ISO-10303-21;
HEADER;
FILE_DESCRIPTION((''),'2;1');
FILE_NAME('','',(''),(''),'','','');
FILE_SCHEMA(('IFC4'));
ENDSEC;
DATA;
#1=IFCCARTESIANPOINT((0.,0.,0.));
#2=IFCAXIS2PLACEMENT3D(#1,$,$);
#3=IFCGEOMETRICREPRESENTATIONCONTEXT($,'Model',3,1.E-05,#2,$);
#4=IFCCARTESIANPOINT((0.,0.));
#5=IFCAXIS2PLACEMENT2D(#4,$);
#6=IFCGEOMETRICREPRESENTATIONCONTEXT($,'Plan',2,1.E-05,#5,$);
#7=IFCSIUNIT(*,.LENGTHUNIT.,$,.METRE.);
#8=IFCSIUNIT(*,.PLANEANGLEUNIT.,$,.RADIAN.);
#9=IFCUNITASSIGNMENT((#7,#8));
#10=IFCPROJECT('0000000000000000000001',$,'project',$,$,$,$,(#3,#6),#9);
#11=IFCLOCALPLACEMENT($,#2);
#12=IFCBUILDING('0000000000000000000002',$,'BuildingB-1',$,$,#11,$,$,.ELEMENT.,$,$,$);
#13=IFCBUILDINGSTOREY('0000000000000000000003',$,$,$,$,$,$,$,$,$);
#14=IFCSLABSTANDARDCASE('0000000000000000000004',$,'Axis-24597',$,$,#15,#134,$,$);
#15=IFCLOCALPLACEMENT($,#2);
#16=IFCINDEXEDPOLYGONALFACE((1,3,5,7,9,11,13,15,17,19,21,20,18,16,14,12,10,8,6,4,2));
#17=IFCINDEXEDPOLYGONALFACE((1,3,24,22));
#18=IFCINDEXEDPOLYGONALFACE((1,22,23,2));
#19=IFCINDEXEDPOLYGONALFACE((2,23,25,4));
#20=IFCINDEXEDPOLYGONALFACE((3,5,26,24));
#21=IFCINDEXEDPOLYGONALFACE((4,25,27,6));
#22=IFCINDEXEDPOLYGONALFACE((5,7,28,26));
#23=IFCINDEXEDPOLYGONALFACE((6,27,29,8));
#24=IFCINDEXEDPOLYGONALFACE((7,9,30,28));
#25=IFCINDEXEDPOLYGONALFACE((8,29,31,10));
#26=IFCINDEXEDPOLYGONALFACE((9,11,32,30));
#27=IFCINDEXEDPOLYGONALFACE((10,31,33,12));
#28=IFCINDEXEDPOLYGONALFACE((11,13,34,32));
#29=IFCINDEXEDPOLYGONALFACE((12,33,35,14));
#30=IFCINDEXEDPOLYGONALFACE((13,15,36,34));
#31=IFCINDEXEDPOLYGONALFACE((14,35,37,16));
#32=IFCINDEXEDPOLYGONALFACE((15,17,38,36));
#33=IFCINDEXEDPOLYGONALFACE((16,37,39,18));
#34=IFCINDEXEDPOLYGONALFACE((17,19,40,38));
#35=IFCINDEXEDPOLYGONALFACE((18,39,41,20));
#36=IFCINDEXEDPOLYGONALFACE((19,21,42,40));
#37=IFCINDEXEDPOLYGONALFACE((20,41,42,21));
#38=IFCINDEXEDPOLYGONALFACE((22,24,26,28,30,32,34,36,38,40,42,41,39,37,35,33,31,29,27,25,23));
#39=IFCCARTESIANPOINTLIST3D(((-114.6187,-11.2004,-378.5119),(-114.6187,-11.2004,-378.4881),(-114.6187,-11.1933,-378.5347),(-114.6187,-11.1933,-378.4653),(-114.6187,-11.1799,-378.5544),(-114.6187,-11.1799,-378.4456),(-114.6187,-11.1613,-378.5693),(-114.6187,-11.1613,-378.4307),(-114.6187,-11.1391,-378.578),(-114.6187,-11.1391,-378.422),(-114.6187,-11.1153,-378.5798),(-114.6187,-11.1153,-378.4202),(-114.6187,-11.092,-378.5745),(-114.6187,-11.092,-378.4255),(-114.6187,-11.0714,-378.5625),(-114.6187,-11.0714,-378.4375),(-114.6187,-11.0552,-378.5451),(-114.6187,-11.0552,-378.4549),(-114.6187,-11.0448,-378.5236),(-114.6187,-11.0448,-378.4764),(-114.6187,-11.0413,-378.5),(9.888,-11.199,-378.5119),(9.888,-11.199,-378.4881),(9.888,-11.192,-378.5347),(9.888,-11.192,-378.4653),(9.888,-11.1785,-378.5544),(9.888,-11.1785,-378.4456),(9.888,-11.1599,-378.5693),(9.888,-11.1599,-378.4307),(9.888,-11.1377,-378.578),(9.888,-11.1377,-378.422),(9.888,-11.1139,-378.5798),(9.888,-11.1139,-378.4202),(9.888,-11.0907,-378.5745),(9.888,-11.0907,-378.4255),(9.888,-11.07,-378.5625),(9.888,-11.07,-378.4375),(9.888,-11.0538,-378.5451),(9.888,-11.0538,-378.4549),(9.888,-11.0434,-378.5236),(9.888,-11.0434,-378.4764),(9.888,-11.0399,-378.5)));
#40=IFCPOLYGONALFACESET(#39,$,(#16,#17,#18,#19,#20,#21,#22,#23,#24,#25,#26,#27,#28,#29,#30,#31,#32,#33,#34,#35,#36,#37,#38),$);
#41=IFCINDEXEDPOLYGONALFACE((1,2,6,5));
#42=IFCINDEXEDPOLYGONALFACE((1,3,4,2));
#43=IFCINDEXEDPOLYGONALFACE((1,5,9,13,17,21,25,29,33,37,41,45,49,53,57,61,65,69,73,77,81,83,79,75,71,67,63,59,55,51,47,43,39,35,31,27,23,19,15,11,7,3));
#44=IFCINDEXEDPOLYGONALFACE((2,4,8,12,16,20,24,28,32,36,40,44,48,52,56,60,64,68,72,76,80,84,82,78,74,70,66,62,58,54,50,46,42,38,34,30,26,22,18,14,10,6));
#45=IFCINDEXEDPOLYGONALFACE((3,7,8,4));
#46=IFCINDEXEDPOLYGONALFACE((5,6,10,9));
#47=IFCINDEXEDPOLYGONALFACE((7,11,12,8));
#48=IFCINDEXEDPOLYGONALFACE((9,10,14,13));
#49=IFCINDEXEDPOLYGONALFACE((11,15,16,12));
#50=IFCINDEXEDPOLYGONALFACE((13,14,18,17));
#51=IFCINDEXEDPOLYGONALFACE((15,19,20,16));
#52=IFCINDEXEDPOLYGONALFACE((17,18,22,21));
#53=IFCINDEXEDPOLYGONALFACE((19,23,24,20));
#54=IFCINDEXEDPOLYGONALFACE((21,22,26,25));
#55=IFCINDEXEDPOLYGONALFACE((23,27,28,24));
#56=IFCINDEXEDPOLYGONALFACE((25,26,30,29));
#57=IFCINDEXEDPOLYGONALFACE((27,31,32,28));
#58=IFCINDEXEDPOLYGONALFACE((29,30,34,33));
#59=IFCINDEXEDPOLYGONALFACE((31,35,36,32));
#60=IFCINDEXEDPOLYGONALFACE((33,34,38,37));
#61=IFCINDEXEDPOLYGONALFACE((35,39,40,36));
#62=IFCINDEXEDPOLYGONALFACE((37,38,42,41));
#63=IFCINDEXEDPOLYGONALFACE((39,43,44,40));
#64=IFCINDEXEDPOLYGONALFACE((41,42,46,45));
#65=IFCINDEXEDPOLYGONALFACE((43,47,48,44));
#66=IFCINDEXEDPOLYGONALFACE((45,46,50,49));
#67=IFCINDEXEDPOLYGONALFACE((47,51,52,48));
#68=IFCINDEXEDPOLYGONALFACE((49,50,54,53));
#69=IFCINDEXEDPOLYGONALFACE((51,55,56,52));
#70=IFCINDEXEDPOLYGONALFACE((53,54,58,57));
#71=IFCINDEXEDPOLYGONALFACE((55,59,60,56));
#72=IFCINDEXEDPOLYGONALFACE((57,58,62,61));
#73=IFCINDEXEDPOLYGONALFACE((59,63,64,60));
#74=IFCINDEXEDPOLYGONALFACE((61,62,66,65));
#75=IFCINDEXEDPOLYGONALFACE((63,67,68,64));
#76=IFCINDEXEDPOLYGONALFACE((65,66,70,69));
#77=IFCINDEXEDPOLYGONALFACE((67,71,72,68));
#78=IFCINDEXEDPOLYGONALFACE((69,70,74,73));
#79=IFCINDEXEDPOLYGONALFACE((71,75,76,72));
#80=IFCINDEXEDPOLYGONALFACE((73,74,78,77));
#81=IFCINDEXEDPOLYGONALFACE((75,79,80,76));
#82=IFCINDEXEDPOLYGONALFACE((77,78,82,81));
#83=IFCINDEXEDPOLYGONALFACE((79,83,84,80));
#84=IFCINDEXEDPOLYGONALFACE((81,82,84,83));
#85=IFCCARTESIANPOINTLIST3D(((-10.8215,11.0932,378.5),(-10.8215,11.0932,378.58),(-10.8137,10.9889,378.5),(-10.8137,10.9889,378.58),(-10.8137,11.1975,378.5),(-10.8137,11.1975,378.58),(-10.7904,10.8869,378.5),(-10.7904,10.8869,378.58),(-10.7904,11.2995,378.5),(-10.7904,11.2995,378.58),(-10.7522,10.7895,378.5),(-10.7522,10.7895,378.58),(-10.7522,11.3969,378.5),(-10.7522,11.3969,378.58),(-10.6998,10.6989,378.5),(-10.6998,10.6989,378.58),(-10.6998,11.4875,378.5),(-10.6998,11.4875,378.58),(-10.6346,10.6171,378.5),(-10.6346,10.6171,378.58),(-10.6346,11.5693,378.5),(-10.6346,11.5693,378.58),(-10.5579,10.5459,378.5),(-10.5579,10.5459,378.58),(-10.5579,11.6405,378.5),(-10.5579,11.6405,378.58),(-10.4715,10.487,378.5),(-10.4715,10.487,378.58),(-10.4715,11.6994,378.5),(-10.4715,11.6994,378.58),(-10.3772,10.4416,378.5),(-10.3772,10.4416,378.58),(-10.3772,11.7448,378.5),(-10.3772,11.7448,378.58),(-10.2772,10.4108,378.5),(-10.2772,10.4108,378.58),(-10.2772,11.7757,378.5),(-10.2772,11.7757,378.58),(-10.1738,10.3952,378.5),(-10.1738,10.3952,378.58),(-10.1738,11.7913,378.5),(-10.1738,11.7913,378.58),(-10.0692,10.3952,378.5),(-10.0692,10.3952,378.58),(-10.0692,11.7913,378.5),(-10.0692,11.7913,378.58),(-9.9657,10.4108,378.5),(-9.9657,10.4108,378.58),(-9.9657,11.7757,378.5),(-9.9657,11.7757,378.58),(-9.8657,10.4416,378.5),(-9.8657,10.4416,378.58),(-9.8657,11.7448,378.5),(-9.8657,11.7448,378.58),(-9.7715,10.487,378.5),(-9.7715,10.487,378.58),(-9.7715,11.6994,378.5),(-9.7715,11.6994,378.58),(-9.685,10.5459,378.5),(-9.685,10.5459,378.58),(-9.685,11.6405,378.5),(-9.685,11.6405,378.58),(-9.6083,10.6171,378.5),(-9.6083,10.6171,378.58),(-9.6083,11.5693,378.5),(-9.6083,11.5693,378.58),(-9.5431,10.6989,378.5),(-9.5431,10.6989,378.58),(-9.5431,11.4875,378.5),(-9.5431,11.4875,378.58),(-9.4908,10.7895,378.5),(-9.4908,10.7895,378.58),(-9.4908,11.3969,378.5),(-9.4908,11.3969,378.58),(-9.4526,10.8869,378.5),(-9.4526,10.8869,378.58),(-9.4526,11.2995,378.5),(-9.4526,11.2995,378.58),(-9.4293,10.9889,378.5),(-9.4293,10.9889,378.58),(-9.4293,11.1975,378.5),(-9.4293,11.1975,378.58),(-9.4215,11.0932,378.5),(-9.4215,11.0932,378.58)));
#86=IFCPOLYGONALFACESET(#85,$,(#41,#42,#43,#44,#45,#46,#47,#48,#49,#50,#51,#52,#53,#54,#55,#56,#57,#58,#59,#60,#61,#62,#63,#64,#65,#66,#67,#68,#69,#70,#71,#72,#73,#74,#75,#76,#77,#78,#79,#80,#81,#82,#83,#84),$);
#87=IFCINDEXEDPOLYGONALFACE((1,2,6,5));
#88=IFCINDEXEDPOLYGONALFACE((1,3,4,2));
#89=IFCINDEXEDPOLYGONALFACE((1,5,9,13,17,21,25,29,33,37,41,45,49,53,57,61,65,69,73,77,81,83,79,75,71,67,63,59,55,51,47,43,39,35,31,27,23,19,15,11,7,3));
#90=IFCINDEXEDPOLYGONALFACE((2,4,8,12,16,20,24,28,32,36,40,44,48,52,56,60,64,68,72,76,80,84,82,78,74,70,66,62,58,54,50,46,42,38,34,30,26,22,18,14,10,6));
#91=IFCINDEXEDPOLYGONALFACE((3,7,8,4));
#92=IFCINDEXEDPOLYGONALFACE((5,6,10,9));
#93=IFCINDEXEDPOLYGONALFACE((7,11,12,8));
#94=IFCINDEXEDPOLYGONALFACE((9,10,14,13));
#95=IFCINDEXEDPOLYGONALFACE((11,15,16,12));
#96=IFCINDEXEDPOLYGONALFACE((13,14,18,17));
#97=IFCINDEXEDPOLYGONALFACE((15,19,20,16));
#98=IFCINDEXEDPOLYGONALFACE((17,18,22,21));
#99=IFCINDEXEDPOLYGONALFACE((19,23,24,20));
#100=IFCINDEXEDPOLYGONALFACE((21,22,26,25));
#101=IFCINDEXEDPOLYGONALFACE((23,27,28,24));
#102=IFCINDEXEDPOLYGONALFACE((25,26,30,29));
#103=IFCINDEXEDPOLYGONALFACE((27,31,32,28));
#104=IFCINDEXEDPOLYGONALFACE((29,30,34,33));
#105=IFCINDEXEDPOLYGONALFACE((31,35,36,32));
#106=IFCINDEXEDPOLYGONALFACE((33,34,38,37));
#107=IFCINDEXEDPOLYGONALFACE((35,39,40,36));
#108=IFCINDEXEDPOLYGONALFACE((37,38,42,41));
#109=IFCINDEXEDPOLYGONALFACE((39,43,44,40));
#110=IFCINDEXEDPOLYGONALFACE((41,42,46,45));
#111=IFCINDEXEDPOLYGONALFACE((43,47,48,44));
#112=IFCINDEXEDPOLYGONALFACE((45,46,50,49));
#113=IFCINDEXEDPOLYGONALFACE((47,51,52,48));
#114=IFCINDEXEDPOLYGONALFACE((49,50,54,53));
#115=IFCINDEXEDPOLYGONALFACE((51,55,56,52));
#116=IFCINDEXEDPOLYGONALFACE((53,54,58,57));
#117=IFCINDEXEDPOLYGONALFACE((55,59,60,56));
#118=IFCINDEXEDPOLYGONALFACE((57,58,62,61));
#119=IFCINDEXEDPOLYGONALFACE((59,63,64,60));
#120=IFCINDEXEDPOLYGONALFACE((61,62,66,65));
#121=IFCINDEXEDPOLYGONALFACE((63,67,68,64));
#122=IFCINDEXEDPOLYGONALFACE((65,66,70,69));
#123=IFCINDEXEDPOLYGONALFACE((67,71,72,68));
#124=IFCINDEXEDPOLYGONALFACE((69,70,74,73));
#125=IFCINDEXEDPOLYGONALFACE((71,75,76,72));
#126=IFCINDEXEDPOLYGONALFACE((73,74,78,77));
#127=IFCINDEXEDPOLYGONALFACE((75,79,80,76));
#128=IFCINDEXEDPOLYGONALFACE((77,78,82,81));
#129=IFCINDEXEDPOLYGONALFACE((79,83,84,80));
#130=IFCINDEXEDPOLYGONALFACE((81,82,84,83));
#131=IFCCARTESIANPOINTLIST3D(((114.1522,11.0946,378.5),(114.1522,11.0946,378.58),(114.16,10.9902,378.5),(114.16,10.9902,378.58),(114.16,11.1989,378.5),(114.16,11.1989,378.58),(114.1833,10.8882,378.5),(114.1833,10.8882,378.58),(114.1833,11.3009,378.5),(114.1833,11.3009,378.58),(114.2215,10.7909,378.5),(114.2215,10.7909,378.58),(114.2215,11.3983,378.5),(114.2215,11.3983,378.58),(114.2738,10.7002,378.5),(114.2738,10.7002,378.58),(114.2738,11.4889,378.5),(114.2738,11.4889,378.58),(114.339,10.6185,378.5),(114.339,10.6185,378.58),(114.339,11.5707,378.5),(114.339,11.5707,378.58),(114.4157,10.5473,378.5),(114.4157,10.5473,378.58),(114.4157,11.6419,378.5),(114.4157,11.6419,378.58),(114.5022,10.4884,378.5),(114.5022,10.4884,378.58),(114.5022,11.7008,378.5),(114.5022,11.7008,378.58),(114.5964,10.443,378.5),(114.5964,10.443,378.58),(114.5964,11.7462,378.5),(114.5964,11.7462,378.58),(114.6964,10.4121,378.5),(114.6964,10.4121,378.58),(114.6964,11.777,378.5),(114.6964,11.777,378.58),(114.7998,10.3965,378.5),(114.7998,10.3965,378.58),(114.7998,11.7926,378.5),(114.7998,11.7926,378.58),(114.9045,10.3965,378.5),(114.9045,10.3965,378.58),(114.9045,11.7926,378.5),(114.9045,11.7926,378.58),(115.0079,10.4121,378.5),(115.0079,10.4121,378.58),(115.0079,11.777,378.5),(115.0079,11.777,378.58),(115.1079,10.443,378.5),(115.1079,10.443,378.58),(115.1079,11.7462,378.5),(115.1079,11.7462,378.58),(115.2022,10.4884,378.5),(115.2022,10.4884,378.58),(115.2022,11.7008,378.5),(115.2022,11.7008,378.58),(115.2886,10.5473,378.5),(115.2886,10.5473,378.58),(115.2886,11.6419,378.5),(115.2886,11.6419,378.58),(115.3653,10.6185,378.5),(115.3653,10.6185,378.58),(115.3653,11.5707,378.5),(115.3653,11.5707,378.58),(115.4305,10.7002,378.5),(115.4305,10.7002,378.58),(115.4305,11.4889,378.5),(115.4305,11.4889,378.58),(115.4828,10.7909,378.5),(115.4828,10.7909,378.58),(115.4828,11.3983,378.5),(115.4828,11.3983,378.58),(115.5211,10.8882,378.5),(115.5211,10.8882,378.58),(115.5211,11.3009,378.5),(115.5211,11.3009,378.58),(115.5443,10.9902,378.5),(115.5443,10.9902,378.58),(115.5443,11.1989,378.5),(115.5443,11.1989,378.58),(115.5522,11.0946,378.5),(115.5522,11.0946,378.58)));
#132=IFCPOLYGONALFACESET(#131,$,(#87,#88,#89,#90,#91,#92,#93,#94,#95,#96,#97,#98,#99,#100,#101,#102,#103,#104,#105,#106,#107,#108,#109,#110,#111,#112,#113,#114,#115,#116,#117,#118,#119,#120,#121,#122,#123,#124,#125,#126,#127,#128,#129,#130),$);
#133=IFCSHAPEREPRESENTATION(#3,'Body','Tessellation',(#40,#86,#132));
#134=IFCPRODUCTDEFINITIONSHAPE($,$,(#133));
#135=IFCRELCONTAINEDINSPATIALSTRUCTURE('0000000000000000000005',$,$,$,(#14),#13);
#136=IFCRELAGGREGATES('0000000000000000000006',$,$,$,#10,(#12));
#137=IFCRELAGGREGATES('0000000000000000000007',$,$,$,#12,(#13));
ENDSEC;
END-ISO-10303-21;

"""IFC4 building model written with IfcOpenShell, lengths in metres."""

from ifc_helpers import new_model, entity, si_unit, frame, origin, origin_2d, place, context, project, spatial, circle, extrude, element, save


model = new_model("IFC4")

# Units and contexts
model_context = context("Model", 3, precision=1e-05, world=origin())
plan_context = context("Plan", 2, precision=1e-05, world=origin_2d())
ifc_project = project(units=[si_unit("LENGTHUNIT", "METRE"), si_unit("PLANEANGLEUNIT", "RADIAN")], contexts=[model_context, plan_context])

# Building, storey
building_placement = place(None, origin())
building = spatial("IfcBuilding", under=ifc_project, at=building_placement, Name="BuildingB-1", CompositionType="ELEMENT")
storey = spatial("IfcBuildingStorey", under=building)

# Slab
element("IfcSlabStandardCase", 1, inside=storey, Name="Axis-24597", context=model_context, shape_type="AdvancedSweptSolid", body=[
    entity("IfcSurfaceCurveSweptAreaSolid", entity("IfcCircleProfileDef", "AREA", None, None, 0.08), None, entity("IfcPolyline", [entity("IfcCartesianPoint", [-9.888, 11.1199, 378.5]), entity("IfcCartesianPoint", [114.6187, 11.1213, 378.5])]), None, None, entity("IfcPlane", entity("IfcAxis2Placement3D", entity("IfcCartesianPoint", [-9.888, 11.1199, 378.5]), entity("IfcDirection", [0.0, 0.0, 1.0]), entity("IfcDirection", [1.0, 0.0, 0.0])))),
    extrude(circle(Radius=0.7), frame((-10.1215, 11.0932, 378.5)), (0.0, 0.0, 1.0), 0.08),
    extrude(circle(Radius=0.7), frame((114.8522, 11.0946, 378.5)), (0.0, 0.0, 1.0), 0.08),
])

save(model, "model.ifc")
